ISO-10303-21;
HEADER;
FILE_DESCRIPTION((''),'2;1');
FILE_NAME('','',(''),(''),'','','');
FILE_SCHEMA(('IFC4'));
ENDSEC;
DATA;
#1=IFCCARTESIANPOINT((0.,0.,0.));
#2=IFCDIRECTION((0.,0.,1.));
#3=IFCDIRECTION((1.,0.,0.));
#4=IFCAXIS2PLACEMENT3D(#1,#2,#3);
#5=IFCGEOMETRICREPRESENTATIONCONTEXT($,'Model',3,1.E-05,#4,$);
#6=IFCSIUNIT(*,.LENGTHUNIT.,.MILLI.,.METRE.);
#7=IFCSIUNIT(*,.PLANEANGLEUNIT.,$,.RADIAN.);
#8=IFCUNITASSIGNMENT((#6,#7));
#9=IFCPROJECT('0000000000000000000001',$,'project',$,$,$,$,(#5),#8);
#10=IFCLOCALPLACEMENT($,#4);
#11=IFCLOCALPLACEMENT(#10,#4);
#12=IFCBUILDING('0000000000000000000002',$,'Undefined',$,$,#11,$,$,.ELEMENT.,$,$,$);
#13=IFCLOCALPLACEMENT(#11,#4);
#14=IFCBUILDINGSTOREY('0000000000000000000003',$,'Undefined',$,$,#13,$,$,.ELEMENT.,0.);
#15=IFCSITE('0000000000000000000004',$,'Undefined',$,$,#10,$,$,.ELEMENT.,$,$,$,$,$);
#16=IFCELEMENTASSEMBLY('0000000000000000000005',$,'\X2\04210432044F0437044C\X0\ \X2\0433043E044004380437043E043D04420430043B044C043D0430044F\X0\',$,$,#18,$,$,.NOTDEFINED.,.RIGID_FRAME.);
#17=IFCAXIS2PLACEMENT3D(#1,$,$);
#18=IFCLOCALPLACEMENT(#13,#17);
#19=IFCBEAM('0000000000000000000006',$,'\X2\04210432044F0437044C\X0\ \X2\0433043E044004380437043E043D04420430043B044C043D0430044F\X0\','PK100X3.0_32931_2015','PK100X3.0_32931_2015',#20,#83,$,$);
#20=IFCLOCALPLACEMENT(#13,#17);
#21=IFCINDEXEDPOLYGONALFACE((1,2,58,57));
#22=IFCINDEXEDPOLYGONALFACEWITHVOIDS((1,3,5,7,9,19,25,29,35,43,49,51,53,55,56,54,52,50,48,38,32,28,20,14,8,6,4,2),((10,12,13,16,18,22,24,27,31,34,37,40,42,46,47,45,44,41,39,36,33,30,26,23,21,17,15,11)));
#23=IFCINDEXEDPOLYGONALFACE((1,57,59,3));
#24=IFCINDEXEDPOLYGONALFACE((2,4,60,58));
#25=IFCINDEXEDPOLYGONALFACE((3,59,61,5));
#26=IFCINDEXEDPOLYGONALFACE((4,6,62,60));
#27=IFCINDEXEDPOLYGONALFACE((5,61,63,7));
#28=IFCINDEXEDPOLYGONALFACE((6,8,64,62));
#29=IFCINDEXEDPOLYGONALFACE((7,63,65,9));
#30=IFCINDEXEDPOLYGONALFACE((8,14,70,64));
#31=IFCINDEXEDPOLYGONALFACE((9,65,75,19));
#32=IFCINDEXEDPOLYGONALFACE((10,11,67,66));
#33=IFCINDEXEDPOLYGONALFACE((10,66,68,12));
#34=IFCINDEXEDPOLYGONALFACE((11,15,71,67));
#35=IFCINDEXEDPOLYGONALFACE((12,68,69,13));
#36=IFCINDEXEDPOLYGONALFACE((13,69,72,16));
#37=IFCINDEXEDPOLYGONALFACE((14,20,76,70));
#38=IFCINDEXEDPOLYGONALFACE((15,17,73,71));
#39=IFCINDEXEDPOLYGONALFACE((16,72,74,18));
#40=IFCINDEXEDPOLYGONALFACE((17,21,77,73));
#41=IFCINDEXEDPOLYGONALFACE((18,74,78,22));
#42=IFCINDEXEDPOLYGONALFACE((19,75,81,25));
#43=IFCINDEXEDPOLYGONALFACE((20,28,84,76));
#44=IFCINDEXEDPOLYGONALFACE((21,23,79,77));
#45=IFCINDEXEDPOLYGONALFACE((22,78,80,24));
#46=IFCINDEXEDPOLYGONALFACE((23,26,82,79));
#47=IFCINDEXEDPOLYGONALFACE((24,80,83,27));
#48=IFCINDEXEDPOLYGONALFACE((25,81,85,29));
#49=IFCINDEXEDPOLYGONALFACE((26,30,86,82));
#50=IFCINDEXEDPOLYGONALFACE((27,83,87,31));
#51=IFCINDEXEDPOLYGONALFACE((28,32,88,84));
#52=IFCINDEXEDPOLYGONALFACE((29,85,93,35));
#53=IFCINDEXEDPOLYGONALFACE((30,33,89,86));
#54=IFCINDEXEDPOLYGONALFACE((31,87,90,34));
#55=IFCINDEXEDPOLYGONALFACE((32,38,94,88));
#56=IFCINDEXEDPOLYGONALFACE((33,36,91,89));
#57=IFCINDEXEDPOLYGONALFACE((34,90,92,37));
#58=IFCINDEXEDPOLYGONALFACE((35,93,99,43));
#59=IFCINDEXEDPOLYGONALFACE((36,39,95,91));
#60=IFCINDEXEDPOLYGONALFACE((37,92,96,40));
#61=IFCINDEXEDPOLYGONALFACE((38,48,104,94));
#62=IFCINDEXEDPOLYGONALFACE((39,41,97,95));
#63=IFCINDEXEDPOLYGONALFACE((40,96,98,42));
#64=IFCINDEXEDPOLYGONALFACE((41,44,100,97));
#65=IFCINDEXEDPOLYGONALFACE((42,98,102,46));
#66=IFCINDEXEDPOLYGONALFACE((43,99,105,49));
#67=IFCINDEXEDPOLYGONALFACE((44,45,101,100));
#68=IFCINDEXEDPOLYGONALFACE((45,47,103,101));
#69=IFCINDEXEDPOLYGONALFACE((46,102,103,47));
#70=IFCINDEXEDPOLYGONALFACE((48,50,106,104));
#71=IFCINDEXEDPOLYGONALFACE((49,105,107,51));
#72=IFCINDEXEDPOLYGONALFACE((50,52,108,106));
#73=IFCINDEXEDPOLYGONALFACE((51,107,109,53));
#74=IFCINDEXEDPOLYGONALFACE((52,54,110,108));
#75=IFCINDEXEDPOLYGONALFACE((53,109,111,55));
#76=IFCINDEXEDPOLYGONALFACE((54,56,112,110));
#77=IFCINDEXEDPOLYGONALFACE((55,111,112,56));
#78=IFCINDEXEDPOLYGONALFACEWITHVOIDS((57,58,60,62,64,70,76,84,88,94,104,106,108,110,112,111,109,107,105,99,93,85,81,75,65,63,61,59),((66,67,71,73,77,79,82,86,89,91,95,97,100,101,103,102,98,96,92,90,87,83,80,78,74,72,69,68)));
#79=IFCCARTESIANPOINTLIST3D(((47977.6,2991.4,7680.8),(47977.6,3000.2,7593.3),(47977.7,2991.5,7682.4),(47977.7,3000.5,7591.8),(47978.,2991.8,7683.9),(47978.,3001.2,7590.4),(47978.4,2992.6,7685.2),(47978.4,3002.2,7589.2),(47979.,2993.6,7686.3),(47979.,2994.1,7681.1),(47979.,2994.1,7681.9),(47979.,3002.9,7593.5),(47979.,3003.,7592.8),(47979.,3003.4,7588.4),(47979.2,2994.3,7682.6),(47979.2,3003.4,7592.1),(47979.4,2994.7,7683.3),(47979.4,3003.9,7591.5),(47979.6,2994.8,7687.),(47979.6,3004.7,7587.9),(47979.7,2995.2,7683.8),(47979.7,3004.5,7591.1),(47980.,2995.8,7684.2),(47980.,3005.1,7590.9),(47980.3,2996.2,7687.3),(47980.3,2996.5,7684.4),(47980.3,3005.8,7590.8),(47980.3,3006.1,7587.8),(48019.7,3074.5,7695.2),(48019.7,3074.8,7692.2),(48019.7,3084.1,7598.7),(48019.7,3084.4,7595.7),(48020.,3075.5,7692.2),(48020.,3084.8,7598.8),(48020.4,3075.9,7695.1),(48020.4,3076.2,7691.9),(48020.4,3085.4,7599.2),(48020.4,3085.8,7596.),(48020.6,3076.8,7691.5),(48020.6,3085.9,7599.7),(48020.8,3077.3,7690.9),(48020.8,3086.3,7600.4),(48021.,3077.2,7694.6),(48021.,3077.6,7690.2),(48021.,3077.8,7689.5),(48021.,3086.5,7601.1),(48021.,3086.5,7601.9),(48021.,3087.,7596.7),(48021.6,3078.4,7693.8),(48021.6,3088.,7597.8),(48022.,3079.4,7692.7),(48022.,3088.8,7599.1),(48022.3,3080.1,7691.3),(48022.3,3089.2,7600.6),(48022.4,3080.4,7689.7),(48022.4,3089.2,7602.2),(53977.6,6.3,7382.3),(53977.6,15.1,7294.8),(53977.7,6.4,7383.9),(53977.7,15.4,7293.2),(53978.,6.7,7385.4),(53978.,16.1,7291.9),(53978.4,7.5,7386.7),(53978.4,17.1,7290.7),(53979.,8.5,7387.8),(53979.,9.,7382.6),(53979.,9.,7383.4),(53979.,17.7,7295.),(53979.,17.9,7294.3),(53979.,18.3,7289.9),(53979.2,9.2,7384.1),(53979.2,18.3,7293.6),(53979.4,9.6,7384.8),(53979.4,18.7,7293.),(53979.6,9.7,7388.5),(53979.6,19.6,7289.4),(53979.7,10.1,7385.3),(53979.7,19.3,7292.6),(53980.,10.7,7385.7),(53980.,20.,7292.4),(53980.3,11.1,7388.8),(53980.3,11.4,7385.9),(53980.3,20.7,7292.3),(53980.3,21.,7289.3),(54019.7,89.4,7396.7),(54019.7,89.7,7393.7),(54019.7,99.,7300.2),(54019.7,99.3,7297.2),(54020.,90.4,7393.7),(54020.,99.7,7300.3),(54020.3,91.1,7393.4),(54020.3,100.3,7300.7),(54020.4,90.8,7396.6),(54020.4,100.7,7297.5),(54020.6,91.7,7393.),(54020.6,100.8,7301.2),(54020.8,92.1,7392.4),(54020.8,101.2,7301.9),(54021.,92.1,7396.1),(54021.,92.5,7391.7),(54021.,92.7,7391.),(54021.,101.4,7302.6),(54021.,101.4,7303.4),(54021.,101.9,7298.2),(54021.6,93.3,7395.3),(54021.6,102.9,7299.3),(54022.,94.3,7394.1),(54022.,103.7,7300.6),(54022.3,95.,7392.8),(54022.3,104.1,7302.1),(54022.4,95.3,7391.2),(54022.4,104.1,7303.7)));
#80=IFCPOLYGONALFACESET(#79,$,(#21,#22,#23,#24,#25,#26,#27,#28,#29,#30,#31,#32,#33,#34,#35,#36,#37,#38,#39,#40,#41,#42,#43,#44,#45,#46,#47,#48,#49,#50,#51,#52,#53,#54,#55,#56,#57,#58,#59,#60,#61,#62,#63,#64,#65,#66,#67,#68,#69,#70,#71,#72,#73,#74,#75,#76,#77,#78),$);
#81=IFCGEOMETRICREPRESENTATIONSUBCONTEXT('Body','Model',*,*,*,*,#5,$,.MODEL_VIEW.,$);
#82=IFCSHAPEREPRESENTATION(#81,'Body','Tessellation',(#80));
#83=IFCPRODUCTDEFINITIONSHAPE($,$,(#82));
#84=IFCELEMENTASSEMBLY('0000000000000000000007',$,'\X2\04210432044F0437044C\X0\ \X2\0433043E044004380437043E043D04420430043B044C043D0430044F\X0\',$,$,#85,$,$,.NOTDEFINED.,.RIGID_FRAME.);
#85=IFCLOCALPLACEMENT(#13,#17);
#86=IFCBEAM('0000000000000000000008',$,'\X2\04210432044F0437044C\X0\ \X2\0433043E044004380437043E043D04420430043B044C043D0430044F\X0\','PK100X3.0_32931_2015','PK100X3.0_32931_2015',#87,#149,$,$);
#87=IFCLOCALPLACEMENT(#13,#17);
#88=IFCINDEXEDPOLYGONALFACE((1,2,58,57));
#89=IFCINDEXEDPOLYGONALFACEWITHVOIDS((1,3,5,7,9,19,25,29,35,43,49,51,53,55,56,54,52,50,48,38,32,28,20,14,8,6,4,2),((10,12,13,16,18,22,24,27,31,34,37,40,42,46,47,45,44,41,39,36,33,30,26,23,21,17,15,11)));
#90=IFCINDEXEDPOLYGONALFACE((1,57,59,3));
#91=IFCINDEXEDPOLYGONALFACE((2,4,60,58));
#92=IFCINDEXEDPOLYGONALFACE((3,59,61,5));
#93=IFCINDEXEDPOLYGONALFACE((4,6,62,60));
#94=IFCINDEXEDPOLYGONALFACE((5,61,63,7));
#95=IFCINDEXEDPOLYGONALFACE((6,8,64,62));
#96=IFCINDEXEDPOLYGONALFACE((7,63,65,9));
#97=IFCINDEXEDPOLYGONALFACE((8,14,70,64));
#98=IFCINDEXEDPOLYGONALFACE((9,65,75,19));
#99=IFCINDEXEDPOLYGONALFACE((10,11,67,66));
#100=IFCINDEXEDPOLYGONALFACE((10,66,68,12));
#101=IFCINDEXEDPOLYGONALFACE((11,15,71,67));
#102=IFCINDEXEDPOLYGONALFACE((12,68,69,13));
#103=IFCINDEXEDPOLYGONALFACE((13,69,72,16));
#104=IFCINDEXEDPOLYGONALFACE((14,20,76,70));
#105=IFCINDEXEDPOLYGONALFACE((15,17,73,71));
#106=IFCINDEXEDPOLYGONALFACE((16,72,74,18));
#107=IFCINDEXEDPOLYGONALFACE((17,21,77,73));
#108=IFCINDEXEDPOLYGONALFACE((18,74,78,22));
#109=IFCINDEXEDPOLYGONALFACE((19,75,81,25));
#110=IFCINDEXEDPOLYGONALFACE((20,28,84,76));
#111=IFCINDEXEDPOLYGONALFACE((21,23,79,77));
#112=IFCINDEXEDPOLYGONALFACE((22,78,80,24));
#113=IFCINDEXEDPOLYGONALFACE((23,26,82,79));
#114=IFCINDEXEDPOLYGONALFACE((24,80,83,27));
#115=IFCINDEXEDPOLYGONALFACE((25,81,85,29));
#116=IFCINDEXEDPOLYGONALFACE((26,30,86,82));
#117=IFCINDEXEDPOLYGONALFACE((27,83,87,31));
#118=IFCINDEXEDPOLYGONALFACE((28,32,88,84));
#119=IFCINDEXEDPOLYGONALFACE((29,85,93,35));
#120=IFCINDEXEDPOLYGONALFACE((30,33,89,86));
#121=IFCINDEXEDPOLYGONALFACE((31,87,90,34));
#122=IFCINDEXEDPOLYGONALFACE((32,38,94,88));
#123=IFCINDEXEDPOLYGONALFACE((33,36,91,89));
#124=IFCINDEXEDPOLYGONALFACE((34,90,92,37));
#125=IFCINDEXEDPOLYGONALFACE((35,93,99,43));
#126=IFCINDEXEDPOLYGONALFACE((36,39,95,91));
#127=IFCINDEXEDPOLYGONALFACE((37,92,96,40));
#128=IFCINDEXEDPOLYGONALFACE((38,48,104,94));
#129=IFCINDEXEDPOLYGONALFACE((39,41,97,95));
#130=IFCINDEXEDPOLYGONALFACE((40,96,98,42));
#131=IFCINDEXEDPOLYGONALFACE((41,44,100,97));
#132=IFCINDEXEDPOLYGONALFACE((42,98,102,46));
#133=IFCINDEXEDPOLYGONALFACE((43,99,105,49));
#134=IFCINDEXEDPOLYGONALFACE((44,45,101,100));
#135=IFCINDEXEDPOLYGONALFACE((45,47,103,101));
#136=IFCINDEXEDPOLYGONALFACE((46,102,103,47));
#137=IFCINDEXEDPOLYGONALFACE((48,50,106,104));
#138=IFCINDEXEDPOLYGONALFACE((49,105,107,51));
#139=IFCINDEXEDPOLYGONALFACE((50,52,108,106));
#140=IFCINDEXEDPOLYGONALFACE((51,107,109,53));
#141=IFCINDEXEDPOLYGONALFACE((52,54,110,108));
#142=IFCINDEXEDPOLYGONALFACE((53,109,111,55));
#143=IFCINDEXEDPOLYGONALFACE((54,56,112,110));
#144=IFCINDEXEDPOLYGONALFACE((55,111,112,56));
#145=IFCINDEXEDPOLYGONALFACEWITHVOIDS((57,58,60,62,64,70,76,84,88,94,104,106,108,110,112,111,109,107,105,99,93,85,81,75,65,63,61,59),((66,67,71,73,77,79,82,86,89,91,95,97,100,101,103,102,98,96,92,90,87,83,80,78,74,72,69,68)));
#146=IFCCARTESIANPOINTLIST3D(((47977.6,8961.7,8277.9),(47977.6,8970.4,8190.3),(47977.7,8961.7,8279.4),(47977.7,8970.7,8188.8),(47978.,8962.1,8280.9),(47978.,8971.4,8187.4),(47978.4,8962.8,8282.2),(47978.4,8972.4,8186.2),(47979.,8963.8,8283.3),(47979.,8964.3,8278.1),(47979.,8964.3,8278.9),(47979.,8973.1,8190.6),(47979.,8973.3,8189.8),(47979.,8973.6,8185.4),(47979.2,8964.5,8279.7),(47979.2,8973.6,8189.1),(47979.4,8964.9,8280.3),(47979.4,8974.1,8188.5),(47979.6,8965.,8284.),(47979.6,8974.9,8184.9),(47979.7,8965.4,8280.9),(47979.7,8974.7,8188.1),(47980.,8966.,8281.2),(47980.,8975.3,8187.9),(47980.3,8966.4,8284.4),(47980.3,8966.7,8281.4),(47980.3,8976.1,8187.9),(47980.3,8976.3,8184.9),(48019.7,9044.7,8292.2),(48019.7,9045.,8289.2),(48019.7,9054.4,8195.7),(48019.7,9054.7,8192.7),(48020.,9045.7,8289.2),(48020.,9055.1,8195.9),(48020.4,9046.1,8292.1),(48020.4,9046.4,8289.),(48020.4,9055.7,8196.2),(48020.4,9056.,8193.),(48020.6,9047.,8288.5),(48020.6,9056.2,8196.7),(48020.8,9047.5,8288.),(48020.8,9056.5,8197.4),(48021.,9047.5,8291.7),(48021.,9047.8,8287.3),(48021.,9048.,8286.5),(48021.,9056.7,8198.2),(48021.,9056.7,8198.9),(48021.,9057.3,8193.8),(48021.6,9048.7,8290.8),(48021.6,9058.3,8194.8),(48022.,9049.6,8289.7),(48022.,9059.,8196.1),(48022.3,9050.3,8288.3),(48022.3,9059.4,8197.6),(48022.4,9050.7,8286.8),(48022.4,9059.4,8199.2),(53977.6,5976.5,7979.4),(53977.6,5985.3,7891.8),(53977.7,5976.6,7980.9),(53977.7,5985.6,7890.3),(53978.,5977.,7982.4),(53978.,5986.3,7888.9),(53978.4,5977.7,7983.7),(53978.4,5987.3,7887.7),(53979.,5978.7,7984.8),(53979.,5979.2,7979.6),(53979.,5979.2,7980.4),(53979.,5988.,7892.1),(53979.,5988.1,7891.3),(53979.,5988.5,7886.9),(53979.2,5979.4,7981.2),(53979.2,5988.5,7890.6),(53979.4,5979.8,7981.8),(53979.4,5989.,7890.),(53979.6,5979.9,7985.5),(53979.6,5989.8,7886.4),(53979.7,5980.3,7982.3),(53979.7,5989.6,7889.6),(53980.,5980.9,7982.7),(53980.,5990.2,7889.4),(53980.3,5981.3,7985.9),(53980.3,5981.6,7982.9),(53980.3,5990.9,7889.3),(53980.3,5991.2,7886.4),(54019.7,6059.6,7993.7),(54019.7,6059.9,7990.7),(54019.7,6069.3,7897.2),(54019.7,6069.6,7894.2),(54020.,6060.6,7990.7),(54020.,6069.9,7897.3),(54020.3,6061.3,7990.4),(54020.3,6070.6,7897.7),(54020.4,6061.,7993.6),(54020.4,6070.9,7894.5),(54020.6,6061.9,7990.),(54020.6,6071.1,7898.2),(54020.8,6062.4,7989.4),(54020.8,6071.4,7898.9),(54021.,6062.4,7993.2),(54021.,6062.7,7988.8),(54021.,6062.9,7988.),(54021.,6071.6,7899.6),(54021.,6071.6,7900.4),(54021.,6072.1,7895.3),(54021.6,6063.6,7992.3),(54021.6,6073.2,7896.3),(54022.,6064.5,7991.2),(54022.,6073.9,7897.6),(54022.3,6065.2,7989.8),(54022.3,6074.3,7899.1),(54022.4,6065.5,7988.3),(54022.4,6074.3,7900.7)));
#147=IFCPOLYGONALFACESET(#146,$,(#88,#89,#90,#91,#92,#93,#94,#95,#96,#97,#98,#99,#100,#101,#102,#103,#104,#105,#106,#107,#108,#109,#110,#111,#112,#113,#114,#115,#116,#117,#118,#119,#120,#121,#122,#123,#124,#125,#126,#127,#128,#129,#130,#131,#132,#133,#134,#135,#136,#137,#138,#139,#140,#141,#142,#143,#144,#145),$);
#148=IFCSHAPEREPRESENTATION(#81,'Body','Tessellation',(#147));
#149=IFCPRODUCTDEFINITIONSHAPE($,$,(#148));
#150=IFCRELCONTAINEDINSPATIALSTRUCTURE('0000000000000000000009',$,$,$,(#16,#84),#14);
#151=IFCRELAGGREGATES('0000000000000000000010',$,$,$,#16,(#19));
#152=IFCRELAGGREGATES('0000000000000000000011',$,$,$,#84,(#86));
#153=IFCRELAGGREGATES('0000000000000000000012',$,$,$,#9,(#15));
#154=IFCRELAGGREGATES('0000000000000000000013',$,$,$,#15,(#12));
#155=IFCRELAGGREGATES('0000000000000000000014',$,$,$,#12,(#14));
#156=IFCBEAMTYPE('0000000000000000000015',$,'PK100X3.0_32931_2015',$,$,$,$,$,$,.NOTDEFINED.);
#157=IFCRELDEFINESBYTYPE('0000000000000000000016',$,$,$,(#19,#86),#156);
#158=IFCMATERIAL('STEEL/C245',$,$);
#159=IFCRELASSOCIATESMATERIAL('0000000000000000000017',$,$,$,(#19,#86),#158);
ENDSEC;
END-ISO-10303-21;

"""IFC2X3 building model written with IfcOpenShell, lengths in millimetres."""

from ifc_helpers import new_model, si_unit, frame, origin_with_axes, origin_2d_with_axis, place, context, subcontext, project, spatial, hollow_rectangle, extrude, material, type_object, element, aggregate, save


model = new_model("IFC2X3")

# Units and contexts
model_context = context("Model", 3, precision=1e-05, world=origin_with_axes())
body_context = subcontext(model_context, "Body", "Model", "MODEL_VIEW")
ifc_project = project(units=[si_unit("LENGTHUNIT", "METRE", prefix="MILLI"), si_unit("PLANEANGLEUNIT", "RADIAN")], contexts=[model_context])

# Site, building, storey
site_placement = place(None, origin_with_axes())
site = spatial("IfcSite", under=ifc_project, at=site_placement, Name="Undefined", CompositionType="ELEMENT")
building_placement = place(site_placement, origin_with_axes())
building = spatial("IfcBuilding", under=site, at=building_placement, Name="Undefined", CompositionType="ELEMENT")
storey_placement = place(building_placement, origin_with_axes())
storey = spatial("IfcBuildingStorey", under=building, at=storey_placement, Name="Undefined", CompositionType="ELEMENT", Elevation=0.0)

# Element assemblies, beams
assembly_1_placement = place(storey_placement, origin_with_axes())
assembly_1 = element("IfcElementAssembly", 1, at=assembly_1_placement, inside=storey, Name="Связь горизонтальная", AssemblyPlace="NOTDEFINED", PredefinedType="RIGID_FRAME")
ifc_material_1 = material(Name="STEEL/C245")
beam_type_1 = type_object("IfcBeamType", Name="PK100X3.0_32931_2015", PredefinedType="NOTDEFINED")
beam_1_placement = place(assembly_1_placement, frame((48000.0, 3040.3, 7641.5), z_axis=(0.0, -0.099504, 0.995037), x_axis=(0.894427, -0.444994, -0.044499)))
beam_1 = element("IfcBeam", 2, at=beam_1_placement, type_object=beam_type_1, material=ifc_material_1, Name="Связь горизонтальная", Description="PK100X3.0_32931_2015", ObjectType="PK100X3.0_32931_2015", context=body_context, shape_type="SweptSolid", body=[
    extrude(hollow_rectangle(XDim=100.0, YDim=100.0, WallThickness=3.0, InnerFilletRadius=3.0, OuterFilletRadius=6.0, at=origin_2d_with_axis()), frame((6708.2, 0.0, 0.0), z_axis=(-1.0, 0.0, 0.0), x_axis=(0.0, -1.0, 0.0)), (0.0, 0.0, 1.0), 6708.2),
])
aggregate(assembly_1, [beam_1])
assembly_2_placement = place(storey_placement, origin_with_axes())
assembly_2 = element("IfcElementAssembly", 3, at=assembly_2_placement, inside=storey, Name="Связь горизонтальная", AssemblyPlace="NOTDEFINED", PredefinedType="RIGID_FRAME")
beam_2_placement = place(assembly_2_placement, frame((48000.0, 9010.5, 8238.5), z_axis=(0.0, -0.099504, 0.995037), x_axis=(0.894427, -0.444994, -0.044499)))
beam_2 = element("IfcBeam", 4, at=beam_2_placement, type_object=beam_type_1, material=ifc_material_1, Name="Связь горизонтальная", Description="PK100X3.0_32931_2015", ObjectType="PK100X3.0_32931_2015", context=body_context, shape_type="SweptSolid", body=[
    extrude(hollow_rectangle(XDim=100.0, YDim=100.0, WallThickness=3.0, InnerFilletRadius=3.0, OuterFilletRadius=6.0, at=origin_2d_with_axis()), frame((6708.2, 0.0, 0.0), z_axis=(-1.0, 0.0, 0.0), x_axis=(0.0, -1.0, 0.0)), (0.0, 0.0, 1.0), 6708.2),
])
aggregate(assembly_2, [beam_2])

save(model, "model.ifc")
